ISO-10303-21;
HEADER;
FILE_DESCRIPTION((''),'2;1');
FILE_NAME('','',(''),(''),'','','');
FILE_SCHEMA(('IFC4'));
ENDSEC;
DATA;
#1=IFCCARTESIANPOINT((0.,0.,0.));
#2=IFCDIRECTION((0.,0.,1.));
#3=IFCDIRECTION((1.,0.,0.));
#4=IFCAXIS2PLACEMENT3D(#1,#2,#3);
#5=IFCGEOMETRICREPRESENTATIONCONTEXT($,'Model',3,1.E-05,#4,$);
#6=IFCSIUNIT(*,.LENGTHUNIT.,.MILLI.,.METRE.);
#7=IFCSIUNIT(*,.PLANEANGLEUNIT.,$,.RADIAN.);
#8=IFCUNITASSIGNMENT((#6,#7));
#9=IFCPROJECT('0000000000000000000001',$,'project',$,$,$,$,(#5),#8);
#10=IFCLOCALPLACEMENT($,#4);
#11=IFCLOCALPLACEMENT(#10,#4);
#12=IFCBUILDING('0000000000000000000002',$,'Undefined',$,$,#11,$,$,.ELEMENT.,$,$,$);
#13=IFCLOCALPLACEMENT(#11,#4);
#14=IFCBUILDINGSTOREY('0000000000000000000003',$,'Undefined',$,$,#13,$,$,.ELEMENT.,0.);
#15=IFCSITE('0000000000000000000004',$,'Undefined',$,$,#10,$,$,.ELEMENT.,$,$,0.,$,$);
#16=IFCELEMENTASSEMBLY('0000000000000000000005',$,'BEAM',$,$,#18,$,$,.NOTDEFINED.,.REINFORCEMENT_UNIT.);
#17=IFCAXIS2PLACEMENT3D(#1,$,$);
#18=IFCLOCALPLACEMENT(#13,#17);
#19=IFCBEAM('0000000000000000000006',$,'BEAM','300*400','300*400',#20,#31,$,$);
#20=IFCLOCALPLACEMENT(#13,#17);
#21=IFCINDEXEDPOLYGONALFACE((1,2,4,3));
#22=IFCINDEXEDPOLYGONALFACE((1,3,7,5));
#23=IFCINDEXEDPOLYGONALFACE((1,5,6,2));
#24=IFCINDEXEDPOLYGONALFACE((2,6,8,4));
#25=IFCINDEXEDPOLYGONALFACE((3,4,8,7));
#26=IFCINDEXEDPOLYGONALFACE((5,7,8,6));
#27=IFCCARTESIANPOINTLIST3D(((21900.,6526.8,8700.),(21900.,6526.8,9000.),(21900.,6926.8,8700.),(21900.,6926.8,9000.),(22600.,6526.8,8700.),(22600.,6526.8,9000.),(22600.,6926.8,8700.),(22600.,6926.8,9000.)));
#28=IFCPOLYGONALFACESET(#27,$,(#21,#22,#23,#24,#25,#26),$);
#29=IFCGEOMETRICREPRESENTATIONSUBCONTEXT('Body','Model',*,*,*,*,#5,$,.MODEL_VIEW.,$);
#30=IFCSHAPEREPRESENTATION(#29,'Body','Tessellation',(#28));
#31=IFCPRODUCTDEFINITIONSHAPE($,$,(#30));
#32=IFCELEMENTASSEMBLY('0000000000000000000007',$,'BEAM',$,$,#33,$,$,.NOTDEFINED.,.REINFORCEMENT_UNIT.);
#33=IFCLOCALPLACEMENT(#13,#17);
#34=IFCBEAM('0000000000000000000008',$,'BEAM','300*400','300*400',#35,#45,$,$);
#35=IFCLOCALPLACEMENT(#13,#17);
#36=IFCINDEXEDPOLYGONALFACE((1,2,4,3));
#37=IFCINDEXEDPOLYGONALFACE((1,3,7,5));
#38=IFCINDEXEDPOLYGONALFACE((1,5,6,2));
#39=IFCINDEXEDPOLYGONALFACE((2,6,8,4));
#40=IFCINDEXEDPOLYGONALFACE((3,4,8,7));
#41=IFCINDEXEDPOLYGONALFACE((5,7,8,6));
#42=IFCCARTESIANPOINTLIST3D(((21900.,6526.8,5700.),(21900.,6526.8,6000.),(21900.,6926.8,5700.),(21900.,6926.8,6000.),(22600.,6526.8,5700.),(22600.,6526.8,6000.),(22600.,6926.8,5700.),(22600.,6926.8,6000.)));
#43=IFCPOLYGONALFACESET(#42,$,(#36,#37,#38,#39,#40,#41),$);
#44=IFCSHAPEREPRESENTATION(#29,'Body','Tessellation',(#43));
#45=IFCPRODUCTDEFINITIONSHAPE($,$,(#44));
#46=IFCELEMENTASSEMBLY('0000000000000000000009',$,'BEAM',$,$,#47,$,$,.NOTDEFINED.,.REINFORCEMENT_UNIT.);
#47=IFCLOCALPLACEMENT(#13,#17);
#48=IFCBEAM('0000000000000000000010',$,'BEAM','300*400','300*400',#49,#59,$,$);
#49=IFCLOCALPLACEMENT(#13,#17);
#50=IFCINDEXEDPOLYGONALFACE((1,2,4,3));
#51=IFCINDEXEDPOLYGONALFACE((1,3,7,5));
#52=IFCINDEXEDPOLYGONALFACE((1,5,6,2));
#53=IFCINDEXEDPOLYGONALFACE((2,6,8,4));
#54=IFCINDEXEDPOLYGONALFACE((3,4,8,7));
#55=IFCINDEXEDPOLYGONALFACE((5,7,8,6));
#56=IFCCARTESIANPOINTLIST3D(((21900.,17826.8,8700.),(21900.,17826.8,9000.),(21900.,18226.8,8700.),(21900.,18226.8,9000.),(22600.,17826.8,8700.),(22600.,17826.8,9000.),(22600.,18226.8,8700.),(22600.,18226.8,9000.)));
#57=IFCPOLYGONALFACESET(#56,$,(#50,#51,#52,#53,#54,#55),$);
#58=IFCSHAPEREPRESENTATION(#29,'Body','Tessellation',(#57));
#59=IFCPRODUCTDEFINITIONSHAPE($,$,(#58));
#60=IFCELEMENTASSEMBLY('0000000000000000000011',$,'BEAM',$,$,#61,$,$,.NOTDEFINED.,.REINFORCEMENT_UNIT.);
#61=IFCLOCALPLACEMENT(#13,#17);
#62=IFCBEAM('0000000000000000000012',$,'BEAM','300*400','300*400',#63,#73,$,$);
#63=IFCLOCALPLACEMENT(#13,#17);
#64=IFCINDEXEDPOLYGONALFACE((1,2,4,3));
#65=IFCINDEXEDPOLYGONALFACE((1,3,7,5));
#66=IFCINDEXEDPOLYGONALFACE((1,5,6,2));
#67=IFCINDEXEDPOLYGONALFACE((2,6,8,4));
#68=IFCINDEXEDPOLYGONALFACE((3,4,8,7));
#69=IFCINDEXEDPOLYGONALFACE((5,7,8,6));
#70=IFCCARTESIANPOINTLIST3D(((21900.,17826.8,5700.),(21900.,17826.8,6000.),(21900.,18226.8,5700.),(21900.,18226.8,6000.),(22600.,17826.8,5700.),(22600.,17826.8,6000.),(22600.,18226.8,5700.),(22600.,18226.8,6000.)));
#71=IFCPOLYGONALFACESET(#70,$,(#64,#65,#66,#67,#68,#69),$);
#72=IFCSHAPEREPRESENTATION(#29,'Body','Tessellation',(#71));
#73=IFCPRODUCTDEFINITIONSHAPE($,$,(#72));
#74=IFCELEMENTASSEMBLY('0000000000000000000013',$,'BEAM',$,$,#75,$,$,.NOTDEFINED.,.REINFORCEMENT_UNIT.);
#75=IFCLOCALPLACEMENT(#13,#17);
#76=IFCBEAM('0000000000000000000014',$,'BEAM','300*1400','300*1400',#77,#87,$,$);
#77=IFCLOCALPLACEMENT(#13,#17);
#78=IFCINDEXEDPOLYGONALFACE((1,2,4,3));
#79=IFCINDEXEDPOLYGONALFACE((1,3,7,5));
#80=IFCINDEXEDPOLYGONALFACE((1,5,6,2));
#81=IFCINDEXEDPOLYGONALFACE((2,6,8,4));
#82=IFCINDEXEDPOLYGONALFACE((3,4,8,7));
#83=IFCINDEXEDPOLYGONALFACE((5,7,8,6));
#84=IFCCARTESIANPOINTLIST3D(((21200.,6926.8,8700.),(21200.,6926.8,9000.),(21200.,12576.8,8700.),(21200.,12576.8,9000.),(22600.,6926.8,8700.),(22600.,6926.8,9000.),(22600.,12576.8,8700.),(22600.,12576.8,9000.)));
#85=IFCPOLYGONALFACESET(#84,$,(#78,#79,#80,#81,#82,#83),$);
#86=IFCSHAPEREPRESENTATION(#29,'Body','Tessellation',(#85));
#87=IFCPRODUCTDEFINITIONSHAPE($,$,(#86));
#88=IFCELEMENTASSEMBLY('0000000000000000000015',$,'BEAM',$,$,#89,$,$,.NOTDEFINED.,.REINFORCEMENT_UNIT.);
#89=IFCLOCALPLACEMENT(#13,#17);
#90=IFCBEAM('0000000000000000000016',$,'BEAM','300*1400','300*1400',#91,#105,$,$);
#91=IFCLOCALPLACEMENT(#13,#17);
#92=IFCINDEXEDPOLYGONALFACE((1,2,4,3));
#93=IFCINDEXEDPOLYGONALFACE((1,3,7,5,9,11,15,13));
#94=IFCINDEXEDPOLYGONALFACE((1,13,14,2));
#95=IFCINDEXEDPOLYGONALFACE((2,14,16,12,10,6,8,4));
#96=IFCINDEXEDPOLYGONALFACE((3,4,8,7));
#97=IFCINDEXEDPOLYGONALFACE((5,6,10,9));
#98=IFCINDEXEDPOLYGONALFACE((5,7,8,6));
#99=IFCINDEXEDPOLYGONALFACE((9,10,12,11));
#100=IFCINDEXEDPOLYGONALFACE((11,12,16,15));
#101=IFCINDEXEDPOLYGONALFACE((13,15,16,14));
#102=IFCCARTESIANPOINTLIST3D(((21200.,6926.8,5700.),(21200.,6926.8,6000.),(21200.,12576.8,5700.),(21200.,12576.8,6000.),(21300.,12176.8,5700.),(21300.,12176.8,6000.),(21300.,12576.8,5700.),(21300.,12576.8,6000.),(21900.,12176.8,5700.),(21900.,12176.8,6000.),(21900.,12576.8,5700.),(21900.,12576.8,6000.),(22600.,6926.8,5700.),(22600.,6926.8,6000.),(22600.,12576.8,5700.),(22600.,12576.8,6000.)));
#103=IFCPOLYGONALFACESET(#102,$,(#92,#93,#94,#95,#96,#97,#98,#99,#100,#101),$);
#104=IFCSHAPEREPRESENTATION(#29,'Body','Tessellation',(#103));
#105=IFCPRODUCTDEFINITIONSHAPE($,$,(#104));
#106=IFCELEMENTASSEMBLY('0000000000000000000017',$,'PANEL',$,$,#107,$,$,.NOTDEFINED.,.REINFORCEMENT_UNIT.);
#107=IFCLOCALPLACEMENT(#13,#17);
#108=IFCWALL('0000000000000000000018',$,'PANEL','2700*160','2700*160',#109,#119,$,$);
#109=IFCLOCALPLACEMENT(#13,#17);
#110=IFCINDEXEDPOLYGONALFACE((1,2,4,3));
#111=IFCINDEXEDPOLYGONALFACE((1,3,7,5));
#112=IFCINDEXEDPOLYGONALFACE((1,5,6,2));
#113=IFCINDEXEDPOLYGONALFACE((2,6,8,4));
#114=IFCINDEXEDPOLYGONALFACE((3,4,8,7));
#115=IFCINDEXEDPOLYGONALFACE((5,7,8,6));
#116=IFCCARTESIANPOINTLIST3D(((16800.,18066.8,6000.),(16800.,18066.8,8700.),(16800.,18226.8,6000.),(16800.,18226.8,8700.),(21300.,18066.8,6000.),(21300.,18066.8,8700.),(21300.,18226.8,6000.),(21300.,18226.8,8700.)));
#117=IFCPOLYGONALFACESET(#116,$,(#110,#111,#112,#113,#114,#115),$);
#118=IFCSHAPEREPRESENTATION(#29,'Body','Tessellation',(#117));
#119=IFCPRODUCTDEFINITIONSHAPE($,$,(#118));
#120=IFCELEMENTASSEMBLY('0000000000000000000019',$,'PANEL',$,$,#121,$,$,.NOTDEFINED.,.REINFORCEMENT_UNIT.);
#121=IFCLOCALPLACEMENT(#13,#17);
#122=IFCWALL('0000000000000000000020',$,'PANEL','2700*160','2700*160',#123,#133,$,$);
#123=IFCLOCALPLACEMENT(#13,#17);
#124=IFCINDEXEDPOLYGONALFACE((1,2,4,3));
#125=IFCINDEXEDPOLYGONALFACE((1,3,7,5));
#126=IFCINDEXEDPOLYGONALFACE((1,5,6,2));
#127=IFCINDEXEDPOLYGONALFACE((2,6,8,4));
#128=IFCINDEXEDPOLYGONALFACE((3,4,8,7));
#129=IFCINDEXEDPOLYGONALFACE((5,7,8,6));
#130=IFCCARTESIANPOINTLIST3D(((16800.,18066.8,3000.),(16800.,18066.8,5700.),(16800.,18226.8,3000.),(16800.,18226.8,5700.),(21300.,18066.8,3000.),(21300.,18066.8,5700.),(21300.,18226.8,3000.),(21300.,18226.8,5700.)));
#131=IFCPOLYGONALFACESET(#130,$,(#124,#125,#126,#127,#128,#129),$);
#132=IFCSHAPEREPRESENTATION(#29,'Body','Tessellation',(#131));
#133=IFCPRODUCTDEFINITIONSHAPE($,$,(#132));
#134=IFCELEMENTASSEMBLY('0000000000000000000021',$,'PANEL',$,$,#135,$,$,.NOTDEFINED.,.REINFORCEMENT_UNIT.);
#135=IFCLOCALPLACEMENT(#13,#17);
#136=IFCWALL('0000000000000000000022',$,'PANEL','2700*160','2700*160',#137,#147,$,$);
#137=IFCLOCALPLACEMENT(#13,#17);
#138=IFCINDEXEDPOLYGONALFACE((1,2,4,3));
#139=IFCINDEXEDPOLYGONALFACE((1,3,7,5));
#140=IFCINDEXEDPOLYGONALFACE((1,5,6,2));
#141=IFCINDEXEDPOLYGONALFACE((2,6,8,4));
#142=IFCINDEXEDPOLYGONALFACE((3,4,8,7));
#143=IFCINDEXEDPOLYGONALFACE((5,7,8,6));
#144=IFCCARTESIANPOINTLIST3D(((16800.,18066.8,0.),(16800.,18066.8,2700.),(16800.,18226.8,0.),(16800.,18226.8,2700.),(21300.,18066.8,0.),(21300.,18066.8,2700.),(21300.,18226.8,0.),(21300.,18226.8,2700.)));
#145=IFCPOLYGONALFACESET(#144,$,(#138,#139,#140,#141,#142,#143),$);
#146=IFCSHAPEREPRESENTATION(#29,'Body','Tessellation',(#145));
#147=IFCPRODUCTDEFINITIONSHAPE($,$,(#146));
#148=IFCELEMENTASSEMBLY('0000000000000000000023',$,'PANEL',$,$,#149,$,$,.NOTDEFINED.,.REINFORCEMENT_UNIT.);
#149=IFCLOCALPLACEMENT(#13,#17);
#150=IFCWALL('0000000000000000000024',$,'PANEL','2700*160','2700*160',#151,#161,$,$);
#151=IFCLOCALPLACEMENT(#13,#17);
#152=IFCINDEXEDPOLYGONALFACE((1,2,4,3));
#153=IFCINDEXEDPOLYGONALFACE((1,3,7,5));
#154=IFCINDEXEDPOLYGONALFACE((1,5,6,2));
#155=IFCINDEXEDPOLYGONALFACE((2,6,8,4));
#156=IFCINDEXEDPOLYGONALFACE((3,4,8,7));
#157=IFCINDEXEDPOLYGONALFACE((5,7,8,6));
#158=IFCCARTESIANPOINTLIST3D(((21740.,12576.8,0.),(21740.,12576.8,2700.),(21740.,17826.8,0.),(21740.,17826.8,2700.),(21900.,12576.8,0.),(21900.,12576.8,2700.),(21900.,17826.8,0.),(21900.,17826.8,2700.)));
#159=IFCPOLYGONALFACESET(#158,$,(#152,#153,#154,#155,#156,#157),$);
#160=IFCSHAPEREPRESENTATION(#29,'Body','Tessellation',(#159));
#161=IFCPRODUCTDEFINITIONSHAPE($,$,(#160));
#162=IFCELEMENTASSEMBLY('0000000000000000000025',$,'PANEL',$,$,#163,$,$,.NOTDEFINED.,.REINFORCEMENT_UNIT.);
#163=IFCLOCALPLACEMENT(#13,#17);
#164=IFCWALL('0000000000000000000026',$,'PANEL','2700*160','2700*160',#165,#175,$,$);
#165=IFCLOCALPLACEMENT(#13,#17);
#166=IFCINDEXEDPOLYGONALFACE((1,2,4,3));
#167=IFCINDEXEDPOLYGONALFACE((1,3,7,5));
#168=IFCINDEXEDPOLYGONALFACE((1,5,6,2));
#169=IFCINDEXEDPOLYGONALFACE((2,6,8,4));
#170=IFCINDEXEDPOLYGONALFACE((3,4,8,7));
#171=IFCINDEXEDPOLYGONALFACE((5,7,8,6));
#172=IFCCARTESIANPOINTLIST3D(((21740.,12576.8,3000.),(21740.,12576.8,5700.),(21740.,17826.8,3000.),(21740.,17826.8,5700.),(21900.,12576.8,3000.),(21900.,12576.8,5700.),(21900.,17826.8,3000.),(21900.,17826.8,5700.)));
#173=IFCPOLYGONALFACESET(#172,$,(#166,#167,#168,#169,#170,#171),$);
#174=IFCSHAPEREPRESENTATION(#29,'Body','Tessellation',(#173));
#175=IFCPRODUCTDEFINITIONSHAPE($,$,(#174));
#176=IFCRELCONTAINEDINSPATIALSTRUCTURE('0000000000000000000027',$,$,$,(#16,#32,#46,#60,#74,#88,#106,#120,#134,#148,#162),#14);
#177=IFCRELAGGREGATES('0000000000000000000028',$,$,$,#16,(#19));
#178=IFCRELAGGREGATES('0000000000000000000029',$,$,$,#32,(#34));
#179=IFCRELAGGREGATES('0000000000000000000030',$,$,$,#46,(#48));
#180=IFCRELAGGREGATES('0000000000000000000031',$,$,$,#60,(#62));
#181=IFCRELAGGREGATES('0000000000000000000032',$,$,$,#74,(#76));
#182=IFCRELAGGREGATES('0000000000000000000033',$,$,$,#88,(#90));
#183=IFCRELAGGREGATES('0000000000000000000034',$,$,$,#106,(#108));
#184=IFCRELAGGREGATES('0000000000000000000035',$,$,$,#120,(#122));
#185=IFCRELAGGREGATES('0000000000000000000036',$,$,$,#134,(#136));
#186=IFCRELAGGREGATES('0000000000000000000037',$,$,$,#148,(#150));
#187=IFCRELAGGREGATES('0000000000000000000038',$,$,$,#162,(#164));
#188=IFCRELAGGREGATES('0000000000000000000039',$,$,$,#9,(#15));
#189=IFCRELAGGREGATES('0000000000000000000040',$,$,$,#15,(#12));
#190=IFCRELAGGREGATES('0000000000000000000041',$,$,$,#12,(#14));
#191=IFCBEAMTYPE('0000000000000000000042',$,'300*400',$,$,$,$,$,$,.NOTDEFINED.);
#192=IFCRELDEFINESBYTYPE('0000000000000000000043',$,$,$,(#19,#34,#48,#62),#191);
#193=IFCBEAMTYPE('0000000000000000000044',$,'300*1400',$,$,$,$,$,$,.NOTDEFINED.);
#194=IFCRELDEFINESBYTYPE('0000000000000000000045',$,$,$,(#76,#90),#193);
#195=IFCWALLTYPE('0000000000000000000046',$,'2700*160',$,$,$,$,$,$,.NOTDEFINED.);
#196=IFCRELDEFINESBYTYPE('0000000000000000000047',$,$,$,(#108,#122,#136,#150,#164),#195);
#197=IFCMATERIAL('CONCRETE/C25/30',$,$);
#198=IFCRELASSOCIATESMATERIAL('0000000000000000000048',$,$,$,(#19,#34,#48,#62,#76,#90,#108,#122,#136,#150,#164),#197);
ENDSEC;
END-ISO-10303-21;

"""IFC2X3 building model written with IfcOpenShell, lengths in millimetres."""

from ifc_helpers import new_model, si_unit, frame, frame_2d, origin_with_axes, origin_2d_with_axis, place, context, subcontext, project, spatial, rectangle, extrude, boolean, material, type_object, element, aggregate, save


model = new_model("IFC2X3")

# Units and contexts
model_context = context("Model", 3, precision=1e-05, world=origin_with_axes())
body_context = subcontext(model_context, "Body", "Model", "MODEL_VIEW")
ifc_project = project(units=[si_unit("LENGTHUNIT", "METRE", prefix="MILLI"), si_unit("PLANEANGLEUNIT", "RADIAN")], contexts=[model_context])

# Site, building, storey
site_placement = place(None, origin_with_axes())
site = spatial("IfcSite", under=ifc_project, at=site_placement, Name="Undefined", CompositionType="ELEMENT", RefElevation=0.0)
building_placement = place(site_placement, origin_with_axes())
building = spatial("IfcBuilding", under=site, at=building_placement, Name="Undefined", CompositionType="ELEMENT")
storey_placement = place(building_placement, origin_with_axes())
storey = spatial("IfcBuildingStorey", under=building, at=storey_placement, Name="Undefined", CompositionType="ELEMENT", Elevation=0.0)

# Shared definitions
ifc_material = material(Name="CONCRETE/C25/30")

# Element assemblies, beams
beam_type_1 = type_object("IfcBeamType", Name="300*400", PredefinedType="NOTDEFINED")
assembly_1_placement = place(storey_placement, origin_with_axes())
assembly_1 = element("IfcElementAssembly", 1, at=assembly_1_placement, inside=storey, Name="BEAM", AssemblyPlace="NOTDEFINED", PredefinedType="REINFORCEMENT_UNIT")
beam_1_placement = place(assembly_1_placement, frame((21900.0, 6726.8, 8850.0), z_axis=(0.0, 0.0, 1.0), x_axis=(1.0, 0.0, 0.0)))
beam_1 = element("IfcBeam", 2, at=beam_1_placement, type_object=beam_type_1, material=ifc_material, Name="BEAM", Description="300*400", ObjectType="300*400", context=body_context, shape_type="SweptSolid", body=[
    extrude(rectangle(XDim=400.0, YDim=300.0, at=origin_2d_with_axis()), frame((700.0, 0.0, 0.0), z_axis=(-1.0, 0.0, 0.0), x_axis=(0.0, -1.0, 0.0)), (0.0, 0.0, 1.0), 700.0),
])
aggregate(assembly_1, [beam_1])
assembly_2_placement = place(storey_placement, origin_with_axes())
assembly_2 = element("IfcElementAssembly", 3, at=assembly_2_placement, inside=storey, Name="BEAM", AssemblyPlace="NOTDEFINED", PredefinedType="REINFORCEMENT_UNIT")
beam_2_placement = place(assembly_2_placement, frame((21900.0, 6726.8, 5850.0), z_axis=(0.0, 0.0, 1.0), x_axis=(1.0, 0.0, 0.0)))
beam_2 = element("IfcBeam", 4, at=beam_2_placement, type_object=beam_type_1, material=ifc_material, Name="BEAM", Description="300*400", ObjectType="300*400", context=body_context, shape_type="SweptSolid", body=[
    extrude(rectangle(XDim=400.0, YDim=300.0, at=origin_2d_with_axis()), frame((700.0, 0.0, 0.0), z_axis=(-1.0, 0.0, 0.0), x_axis=(0.0, -1.0, 0.0)), (0.0, 0.0, 1.0), 700.0),
])
aggregate(assembly_2, [beam_2])
assembly_3_placement = place(storey_placement, origin_with_axes())
assembly_3 = element("IfcElementAssembly", 5, at=assembly_3_placement, inside=storey, Name="BEAM", AssemblyPlace="NOTDEFINED", PredefinedType="REINFORCEMENT_UNIT")
beam_3_placement = place(assembly_3_placement, frame((21900.0, 18026.8, 8850.0), z_axis=(0.0, 0.0, 1.0), x_axis=(1.0, 0.0, 0.0)))
beam_3 = element("IfcBeam", 6, at=beam_3_placement, type_object=beam_type_1, material=ifc_material, Name="BEAM", Description="300*400", ObjectType="300*400", context=body_context, shape_type="SweptSolid", body=[
    extrude(rectangle(XDim=400.0, YDim=300.0, at=origin_2d_with_axis()), frame((700.0, 0.0, 0.0), z_axis=(-1.0, 0.0, 0.0), x_axis=(0.0, -1.0, 0.0)), (0.0, 0.0, 1.0), 700.0),
])
aggregate(assembly_3, [beam_3])
assembly_4_placement = place(storey_placement, origin_with_axes())
assembly_4 = element("IfcElementAssembly", 7, at=assembly_4_placement, inside=storey, Name="BEAM", AssemblyPlace="NOTDEFINED", PredefinedType="REINFORCEMENT_UNIT")
beam_4_placement = place(assembly_4_placement, frame((21900.0, 18026.8, 5850.0), z_axis=(0.0, 0.0, 1.0), x_axis=(1.0, 0.0, 0.0)))
beam_4 = element("IfcBeam", 8, at=beam_4_placement, type_object=beam_type_1, material=ifc_material, Name="BEAM", Description="300*400", ObjectType="300*400", context=body_context, shape_type="SweptSolid", body=[
    extrude(rectangle(XDim=400.0, YDim=300.0, at=origin_2d_with_axis()), frame((700.0, 0.0, 0.0), z_axis=(-1.0, 0.0, 0.0), x_axis=(0.0, -1.0, 0.0)), (0.0, 0.0, 1.0), 700.0),
])
aggregate(assembly_4, [beam_4])
assembly_5_placement = place(storey_placement, origin_with_axes())
assembly_5 = element("IfcElementAssembly", 9, at=assembly_5_placement, inside=storey, Name="BEAM", AssemblyPlace="NOTDEFINED", PredefinedType="REINFORCEMENT_UNIT")
beam_type_2 = type_object("IfcBeamType", Name="300*1400", PredefinedType="NOTDEFINED")
beam_5_placement = place(assembly_5_placement, frame((21900.0, 6926.8, 8850.0), z_axis=(0.0, 0.0, 1.0), x_axis=(0.0, 1.0, 0.0)))
beam_5 = element("IfcBeam", 10, at=beam_5_placement, type_object=beam_type_2, material=ifc_material, Name="BEAM", Description="300*1400", ObjectType="300*1400", context=body_context, shape_type="SweptSolid", body=[
    extrude(rectangle(XDim=1400.0, YDim=300.0, at=origin_2d_with_axis()), frame((5650.0, 0.0, 0.0), z_axis=(-1.0, 0.0, 0.0), x_axis=(0.0, -1.0, 0.0)), (0.0, 0.0, 1.0), 5650.0),
])
aggregate(assembly_5, [beam_5])
assembly_6_placement = place(storey_placement, origin_with_axes())
assembly_6 = element("IfcElementAssembly", 11, at=assembly_6_placement, inside=storey, Name="BEAM", AssemblyPlace="NOTDEFINED", PredefinedType="REINFORCEMENT_UNIT")
beam_6_placement = place(assembly_6_placement, frame((21900.0, 6926.8, 5850.0), z_axis=(0.0, 0.0, 1.0), x_axis=(0.0, 1.0, 0.0)))
beam_6 = element("IfcBeam", 12, at=beam_6_placement, type_object=beam_type_2, material=ifc_material, Name="BEAM", Description="300*1400", ObjectType="300*1400", context=body_context, shape_type="CSG", body=[
    boolean("DIFFERENCE", extrude(rectangle(XDim=1400.0, YDim=300.0, at=origin_2d_with_axis()), frame((5650.0, 0.0, 0.0), z_axis=(-1.0, 0.0, 0.0), x_axis=(0.0, -1.0, 0.0)), (0.0, 0.0, 1.0), 5650.0), extrude(rectangle(XDim=600.0, YDim=400.0, at=origin_2d_with_axis()), frame((5450.0, 300.0, 150.0), z_axis=(0.0, 0.0, -1.0), x_axis=(0.0, 1.0, 0.0)), (0.0, 0.0, 1.0), 3000.0)),
])
aggregate(assembly_6, [beam_6])

# Element assemblies, walls
assembly_7_placement = place(storey_placement, origin_with_axes())
assembly_7 = element("IfcElementAssembly", 13, at=assembly_7_placement, inside=storey, Name="PANEL", AssemblyPlace="NOTDEFINED", PredefinedType="REINFORCEMENT_UNIT")
wall_type = type_object("IfcWallType", Name="2700*160", PredefinedType="NOTDEFINED")
wall_1_placement = place(assembly_7_placement, frame((16800.0, 18146.8, 6000.0), z_axis=(0.0, 0.0, 1.0), x_axis=(1.0, 0.0, 0.0)))
wall_1 = element("IfcWall", 14, at=wall_1_placement, type_object=wall_type, material=ifc_material, Name="PANEL", Description="2700*160", ObjectType="2700*160", context=body_context, shape_type="SweptSolid", body=[
    extrude(rectangle(XDim=4500.0, YDim=160.0, at=frame_2d((0.0, 2250.0), x_axis=(0.0, -1.0))), frame((0.0, 0.0, 0.0), z_axis=(0.0, 0.0, 1.0), x_axis=(0.0, -1.0, 0.0)), (0.0, 0.0, 1.0), 2700.0),
])
aggregate(assembly_7, [wall_1])
assembly_8_placement = place(storey_placement, origin_with_axes())
assembly_8 = element("IfcElementAssembly", 15, at=assembly_8_placement, inside=storey, Name="PANEL", AssemblyPlace="NOTDEFINED", PredefinedType="REINFORCEMENT_UNIT")
wall_2_placement = place(assembly_8_placement, frame((16800.0, 18146.8, 3000.0), z_axis=(0.0, 0.0, 1.0), x_axis=(1.0, 0.0, 0.0)))
wall_2 = element("IfcWall", 16, at=wall_2_placement, type_object=wall_type, material=ifc_material, Name="PANEL", Description="2700*160", ObjectType="2700*160", context=body_context, shape_type="SweptSolid", body=[
    extrude(rectangle(XDim=4500.0, YDim=160.0, at=frame_2d((0.0, 2250.0), x_axis=(0.0, -1.0))), frame((0.0, 0.0, 0.0), z_axis=(0.0, 0.0, 1.0), x_axis=(0.0, -1.0, 0.0)), (0.0, 0.0, 1.0), 2700.0),
])
aggregate(assembly_8, [wall_2])
assembly_9_placement = place(storey_placement, origin_with_axes())
assembly_9 = element("IfcElementAssembly", 17, at=assembly_9_placement, inside=storey, Name="PANEL", AssemblyPlace="NOTDEFINED", PredefinedType="REINFORCEMENT_UNIT")
wall_3_placement = place(assembly_9_placement, frame((21300.0, 18146.8, 0.0), z_axis=(0.0, 0.0, 1.0), x_axis=(-1.0, 0.0, 0.0)))
wall_3 = element("IfcWall", 18, at=wall_3_placement, type_object=wall_type, material=ifc_material, Name="PANEL", Description="2700*160", ObjectType="2700*160", context=body_context, shape_type="SweptSolid", body=[
    extrude(rectangle(XDim=4500.0, YDim=160.0, at=frame_2d((0.0, 2250.0), x_axis=(0.0, -1.0))), frame((0.0, 0.0, 0.0), z_axis=(0.0, 0.0, 1.0), x_axis=(0.0, -1.0, 0.0)), (0.0, 0.0, 1.0), 2700.0),
])
aggregate(assembly_9, [wall_3])
assembly_10_placement = place(storey_placement, origin_with_axes())
assembly_10 = element("IfcElementAssembly", 19, at=assembly_10_placement, inside=storey, Name="PANEL", AssemblyPlace="NOTDEFINED", PredefinedType="REINFORCEMENT_UNIT")
wall_4_placement = place(assembly_10_placement, frame((21820.0, 17826.8, 0.0), z_axis=(0.0, 0.0, 1.0), x_axis=(0.0, -1.0, 0.0)))
wall_4 = element("IfcWall", 20, at=wall_4_placement, type_object=wall_type, material=ifc_material, Name="PANEL", Description="2700*160", ObjectType="2700*160", context=body_context, shape_type="SweptSolid", body=[
    extrude(rectangle(XDim=5250.0, YDim=160.0, at=frame_2d((0.0, 2625.0), x_axis=(0.0, -1.0))), frame((0.0, 0.0, 0.0), z_axis=(0.0, 0.0, 1.0), x_axis=(0.0, -1.0, 0.0)), (0.0, 0.0, 1.0), 2700.0),
])
aggregate(assembly_10, [wall_4])
assembly_11_placement = place(storey_placement, origin_with_axes())
assembly_11 = element("IfcElementAssembly", 21, at=assembly_11_placement, inside=storey, Name="PANEL", AssemblyPlace="NOTDEFINED", PredefinedType="REINFORCEMENT_UNIT")
wall_5_placement = place(assembly_11_placement, frame((21820.0, 17826.8, 3000.0), z_axis=(0.0, 0.0, 1.0), x_axis=(0.0, -1.0, 0.0)))
wall_5 = element("IfcWall", 22, at=wall_5_placement, type_object=wall_type, material=ifc_material, Name="PANEL", Description="2700*160", ObjectType="2700*160", context=body_context, shape_type="SweptSolid", body=[
    extrude(rectangle(XDim=5250.0, YDim=160.0, at=frame_2d((0.0, 2625.0), x_axis=(0.0, -1.0))), frame((0.0, 0.0, 0.0), z_axis=(0.0, 0.0, 1.0), x_axis=(0.0, -1.0, 0.0)), (0.0, 0.0, 1.0), 2700.0),
])
aggregate(assembly_11, [wall_5])

save(model, "model.ifc")
